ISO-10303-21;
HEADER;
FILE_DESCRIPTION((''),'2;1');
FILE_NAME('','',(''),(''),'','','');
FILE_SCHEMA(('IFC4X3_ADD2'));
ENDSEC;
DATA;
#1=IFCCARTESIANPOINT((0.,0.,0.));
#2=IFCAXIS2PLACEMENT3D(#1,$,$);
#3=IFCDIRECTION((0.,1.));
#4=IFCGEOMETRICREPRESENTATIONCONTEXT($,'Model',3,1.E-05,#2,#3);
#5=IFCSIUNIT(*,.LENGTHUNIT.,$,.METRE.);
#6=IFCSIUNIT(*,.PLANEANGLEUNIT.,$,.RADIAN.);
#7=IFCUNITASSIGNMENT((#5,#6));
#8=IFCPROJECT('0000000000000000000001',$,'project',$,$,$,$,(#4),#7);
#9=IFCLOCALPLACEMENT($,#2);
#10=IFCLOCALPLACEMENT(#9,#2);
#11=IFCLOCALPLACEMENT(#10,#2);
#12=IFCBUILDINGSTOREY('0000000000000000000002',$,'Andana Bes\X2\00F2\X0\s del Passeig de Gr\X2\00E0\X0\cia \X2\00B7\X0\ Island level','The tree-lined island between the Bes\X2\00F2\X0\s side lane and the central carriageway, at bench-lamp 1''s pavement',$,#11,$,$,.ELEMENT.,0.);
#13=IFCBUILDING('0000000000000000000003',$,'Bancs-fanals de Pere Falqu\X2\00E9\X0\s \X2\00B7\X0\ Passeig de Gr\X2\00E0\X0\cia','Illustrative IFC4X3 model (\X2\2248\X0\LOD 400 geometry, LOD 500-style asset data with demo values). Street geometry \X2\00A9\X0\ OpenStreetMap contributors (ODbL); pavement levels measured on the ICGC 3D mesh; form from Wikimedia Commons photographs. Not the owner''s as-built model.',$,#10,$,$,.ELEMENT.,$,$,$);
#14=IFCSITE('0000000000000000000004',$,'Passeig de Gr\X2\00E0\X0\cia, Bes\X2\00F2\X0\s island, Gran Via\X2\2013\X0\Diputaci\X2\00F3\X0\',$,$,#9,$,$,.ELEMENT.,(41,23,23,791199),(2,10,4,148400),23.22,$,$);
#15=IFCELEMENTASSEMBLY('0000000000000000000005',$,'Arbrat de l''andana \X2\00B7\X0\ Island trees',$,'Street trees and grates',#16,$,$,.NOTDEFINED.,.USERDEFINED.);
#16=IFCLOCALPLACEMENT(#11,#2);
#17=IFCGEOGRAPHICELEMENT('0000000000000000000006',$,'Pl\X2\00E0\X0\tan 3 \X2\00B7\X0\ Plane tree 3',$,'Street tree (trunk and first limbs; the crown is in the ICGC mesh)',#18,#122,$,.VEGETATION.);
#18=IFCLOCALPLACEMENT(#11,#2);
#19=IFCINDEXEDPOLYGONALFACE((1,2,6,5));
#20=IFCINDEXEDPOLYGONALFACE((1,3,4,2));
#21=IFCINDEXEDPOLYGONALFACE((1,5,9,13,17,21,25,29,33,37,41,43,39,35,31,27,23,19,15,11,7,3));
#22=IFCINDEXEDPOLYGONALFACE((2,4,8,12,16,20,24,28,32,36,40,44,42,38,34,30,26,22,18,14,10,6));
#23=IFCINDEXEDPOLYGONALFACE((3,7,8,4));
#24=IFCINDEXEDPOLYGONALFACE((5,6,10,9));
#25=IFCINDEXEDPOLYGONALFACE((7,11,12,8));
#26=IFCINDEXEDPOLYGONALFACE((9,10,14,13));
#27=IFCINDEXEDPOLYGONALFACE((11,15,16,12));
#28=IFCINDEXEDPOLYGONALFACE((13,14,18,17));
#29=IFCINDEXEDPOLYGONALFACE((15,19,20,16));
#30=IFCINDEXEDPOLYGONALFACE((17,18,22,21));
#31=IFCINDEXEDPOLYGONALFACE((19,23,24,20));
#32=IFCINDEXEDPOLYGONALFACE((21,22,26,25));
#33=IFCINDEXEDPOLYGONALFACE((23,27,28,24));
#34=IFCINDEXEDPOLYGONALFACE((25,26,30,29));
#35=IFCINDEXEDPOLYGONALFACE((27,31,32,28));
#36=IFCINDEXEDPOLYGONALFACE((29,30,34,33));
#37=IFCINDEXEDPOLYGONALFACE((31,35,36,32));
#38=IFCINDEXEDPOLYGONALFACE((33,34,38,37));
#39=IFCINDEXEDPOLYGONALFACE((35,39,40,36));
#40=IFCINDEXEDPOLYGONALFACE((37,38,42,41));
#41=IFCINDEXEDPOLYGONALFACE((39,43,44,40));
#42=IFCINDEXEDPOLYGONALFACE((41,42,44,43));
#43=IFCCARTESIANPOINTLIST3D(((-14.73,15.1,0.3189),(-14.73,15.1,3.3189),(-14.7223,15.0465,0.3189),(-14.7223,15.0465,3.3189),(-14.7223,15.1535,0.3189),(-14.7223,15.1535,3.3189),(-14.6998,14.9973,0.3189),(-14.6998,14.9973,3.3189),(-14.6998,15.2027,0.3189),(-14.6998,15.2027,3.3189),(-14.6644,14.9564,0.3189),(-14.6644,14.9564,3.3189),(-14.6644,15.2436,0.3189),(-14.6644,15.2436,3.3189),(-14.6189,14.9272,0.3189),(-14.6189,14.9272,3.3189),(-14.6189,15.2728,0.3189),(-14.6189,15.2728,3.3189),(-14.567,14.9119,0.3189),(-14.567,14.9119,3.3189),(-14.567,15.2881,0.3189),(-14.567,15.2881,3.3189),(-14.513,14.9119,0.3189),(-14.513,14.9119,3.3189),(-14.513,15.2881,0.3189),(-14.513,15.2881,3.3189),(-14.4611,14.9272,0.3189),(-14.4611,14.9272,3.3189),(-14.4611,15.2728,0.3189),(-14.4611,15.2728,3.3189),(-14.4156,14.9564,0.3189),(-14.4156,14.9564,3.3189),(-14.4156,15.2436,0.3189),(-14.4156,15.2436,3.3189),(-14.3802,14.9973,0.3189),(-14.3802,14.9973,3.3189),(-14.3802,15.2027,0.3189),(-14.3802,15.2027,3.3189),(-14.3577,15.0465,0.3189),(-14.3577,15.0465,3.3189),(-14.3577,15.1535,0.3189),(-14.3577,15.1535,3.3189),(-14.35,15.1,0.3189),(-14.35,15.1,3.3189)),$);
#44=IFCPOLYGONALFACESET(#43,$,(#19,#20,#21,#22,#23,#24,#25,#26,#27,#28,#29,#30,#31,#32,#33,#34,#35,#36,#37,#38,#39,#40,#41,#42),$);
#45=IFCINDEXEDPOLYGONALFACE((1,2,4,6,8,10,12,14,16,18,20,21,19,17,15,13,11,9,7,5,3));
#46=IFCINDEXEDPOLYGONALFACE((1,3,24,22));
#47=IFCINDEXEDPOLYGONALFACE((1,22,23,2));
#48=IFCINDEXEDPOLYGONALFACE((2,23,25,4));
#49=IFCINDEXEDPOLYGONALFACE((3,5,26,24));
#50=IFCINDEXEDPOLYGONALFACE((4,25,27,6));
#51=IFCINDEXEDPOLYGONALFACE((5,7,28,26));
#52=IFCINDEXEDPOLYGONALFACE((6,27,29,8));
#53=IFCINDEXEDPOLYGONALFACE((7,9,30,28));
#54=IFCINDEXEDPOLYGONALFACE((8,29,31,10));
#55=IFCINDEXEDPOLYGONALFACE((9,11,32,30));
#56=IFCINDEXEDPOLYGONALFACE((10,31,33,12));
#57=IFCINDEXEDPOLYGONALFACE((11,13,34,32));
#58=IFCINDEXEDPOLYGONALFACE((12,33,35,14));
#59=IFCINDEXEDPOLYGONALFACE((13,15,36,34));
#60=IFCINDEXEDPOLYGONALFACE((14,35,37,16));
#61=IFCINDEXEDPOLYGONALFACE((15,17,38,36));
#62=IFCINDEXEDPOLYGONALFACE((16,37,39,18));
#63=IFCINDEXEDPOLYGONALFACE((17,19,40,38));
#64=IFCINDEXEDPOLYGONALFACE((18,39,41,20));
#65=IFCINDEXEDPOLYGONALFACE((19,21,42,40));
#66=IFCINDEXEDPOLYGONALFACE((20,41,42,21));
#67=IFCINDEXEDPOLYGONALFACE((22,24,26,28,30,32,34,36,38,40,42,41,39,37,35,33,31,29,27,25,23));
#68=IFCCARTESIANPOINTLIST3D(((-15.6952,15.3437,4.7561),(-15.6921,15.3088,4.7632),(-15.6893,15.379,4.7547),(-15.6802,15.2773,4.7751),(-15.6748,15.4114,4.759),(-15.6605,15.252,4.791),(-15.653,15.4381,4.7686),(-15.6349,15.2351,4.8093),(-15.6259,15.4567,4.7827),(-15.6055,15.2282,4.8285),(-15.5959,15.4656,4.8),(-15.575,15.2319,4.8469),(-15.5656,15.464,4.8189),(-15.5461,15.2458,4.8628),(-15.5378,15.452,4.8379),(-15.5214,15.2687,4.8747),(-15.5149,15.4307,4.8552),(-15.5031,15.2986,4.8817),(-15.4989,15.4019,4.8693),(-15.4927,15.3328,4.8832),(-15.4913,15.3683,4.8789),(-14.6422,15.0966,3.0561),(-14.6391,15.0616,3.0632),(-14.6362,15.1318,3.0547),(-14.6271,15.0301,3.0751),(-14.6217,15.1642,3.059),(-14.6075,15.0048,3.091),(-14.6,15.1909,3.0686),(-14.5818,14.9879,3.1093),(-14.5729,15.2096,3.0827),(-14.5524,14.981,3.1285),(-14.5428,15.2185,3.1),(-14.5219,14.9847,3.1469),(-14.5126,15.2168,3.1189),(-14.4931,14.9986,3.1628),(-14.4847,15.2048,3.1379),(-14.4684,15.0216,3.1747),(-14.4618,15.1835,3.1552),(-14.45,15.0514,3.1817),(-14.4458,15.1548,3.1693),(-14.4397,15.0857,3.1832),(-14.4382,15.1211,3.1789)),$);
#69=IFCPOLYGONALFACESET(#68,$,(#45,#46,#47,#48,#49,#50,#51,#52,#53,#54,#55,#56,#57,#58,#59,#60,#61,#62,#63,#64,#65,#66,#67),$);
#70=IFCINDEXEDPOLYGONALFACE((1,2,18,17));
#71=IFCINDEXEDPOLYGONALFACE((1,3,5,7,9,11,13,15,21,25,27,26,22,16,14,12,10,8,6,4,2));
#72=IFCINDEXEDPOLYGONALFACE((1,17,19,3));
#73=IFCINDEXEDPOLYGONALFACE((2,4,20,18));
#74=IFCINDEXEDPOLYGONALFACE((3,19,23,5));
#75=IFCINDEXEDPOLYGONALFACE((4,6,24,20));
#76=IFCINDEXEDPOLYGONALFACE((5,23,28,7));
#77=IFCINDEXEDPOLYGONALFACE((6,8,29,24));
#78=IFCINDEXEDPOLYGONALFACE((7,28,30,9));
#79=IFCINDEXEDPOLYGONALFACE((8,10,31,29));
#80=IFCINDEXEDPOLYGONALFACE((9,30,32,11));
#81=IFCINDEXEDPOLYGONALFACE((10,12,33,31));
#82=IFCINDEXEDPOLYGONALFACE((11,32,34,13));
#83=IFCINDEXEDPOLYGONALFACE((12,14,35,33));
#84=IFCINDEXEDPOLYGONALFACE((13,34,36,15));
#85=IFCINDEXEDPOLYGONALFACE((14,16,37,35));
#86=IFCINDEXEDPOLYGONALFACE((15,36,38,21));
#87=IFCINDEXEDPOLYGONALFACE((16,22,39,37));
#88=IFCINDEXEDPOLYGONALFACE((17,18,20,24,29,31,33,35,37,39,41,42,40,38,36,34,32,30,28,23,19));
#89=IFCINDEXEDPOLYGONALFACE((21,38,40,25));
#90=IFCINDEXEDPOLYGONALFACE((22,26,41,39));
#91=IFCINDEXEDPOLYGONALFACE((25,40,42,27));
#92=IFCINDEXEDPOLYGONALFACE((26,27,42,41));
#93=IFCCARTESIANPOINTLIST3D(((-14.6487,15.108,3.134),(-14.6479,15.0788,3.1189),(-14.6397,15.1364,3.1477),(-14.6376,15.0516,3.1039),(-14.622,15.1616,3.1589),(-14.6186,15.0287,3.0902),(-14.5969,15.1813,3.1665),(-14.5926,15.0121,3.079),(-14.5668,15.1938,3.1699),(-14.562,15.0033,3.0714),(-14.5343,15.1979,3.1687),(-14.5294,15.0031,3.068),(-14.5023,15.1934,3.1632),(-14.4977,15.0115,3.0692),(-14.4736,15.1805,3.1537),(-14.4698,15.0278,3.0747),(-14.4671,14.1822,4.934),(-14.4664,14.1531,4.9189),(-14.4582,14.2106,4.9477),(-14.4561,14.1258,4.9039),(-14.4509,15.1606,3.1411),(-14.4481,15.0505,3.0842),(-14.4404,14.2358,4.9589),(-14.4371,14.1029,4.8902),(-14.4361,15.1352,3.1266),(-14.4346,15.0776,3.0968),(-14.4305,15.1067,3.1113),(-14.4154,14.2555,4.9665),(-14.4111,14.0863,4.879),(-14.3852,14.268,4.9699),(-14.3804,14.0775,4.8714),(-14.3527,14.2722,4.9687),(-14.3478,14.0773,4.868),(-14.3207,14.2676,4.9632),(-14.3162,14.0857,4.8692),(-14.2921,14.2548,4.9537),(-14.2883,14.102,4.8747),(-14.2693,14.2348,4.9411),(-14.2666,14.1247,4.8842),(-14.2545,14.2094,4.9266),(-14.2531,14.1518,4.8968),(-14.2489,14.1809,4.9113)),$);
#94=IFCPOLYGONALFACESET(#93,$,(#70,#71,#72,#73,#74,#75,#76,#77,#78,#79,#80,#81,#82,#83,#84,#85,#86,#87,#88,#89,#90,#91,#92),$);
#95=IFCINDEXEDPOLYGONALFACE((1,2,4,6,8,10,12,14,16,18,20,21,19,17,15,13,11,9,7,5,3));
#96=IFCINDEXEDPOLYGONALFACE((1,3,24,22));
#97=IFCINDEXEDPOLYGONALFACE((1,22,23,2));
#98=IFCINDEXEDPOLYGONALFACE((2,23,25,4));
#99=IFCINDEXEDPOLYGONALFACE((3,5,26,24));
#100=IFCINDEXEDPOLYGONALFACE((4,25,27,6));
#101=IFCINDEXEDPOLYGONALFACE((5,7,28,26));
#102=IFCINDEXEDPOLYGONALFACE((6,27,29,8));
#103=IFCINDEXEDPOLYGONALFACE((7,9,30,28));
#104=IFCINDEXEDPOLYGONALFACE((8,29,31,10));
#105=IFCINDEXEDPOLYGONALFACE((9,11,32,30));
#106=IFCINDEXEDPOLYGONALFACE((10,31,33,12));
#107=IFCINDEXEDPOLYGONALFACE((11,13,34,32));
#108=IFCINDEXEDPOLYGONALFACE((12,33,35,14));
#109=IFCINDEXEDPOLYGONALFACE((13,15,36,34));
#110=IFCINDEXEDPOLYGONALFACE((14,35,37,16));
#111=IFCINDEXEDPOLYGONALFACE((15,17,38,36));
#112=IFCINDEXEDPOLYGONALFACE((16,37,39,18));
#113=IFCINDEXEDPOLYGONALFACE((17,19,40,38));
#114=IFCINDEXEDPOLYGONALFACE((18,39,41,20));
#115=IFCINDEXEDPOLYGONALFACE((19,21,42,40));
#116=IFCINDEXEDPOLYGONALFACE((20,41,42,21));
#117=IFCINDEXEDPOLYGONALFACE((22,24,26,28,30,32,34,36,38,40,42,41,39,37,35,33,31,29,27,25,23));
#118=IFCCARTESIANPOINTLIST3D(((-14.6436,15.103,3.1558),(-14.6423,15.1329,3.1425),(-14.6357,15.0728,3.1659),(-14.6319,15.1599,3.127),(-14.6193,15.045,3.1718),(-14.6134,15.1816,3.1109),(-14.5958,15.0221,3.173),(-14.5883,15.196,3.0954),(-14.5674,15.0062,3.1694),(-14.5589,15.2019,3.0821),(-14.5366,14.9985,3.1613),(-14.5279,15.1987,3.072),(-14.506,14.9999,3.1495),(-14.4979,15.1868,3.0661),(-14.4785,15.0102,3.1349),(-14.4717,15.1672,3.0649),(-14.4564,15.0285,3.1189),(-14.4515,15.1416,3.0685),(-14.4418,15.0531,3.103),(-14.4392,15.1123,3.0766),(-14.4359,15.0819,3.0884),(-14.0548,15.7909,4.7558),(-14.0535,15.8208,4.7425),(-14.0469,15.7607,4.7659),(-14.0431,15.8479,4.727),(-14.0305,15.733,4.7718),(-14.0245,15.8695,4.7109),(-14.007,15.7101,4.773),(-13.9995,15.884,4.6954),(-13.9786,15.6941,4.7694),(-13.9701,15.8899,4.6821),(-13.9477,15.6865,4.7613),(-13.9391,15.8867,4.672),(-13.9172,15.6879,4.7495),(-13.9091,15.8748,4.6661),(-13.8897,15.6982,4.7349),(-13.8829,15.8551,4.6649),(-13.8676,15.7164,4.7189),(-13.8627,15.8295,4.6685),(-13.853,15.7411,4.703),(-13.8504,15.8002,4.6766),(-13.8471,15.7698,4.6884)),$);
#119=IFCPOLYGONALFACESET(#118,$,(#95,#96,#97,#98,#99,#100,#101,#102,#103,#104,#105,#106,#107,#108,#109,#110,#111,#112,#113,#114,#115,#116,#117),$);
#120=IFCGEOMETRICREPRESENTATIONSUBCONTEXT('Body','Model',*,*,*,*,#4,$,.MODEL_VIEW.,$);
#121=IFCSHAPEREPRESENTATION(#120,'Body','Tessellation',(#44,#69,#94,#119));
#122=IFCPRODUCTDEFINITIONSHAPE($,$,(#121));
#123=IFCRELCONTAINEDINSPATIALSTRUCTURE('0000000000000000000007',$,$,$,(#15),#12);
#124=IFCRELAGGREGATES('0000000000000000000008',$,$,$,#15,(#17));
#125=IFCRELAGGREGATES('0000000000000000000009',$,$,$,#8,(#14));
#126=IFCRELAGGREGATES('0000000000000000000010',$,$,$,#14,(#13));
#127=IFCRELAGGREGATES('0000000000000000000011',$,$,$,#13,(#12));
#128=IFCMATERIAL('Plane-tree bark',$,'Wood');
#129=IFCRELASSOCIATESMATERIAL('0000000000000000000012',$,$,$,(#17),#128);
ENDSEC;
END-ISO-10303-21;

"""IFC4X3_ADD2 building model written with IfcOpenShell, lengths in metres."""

from ifc_helpers import new_model, si_unit, direction, frame, origin, origin_2d_with_axis, place, context, subcontext, project, spatial, circle, extrude, material, element, aggregate, save


model = new_model("IFC4X3_ADD2")

# Units and contexts
model_context = context("Model", 3, precision=1e-05, world=origin(), true_north=direction((0.0, 1.0)))
body_context = subcontext(model_context, "Body", "Model", "MODEL_VIEW")
ifc_project = project(units=[si_unit("LENGTHUNIT", "METRE"), si_unit("PLANEANGLEUNIT", "RADIAN")], contexts=[model_context])

# Site, building, storey
site_placement = place(None, origin())
site = spatial("IfcSite", under=ifc_project, at=site_placement, Name="Passeig de Gràcia, Besòs island, Gran Via–Diputació", CompositionType="ELEMENT", RefLatitude=(41, 23, 23, 791199), RefLongitude=(2, 10, 4, 148400), RefElevation=23.22)
building_placement = place(site_placement, origin())
building = spatial("IfcBuilding", under=site, at=building_placement, Name="Bancs-fanals de Pere Falqués · Passeig de Gràcia", Description="Illustrative IFC4X3 model (≈LOD 400 geometry, LOD 500-style asset data with demo values). Street geometry © OpenStreetMap contributors (ODbL); pavement levels measured on the ICGC 3D mesh; form from Wikimedia Commons photographs. Not the owner's as-built model.", CompositionType="ELEMENT")
storey_placement = place(building_placement, origin())
storey = spatial("IfcBuildingStorey", under=building, at=storey_placement, Name="Andana Besòs del Passeig de Gràcia · Island level", Description="The tree-lined island between the Besòs side lane and the central carriageway, at bench-lamp 1's pavement", CompositionType="ELEMENT", Elevation=0.0)

# Element assembly
assembly_1_placement = place(building_placement, origin())
assembly_1 = element("IfcElementAssembly", 1, at=assembly_1_placement, inside=storey, Name="Arbrat de l'andana · Island trees", ObjectType="Street trees and grates", AssemblyPlace="NOTDEFINED", PredefinedType="USERDEFINED")

# Geographic element
ifc_material_1 = material(Name="Plane-tree bark", Category="Wood")
geographic_element_1_placement = place(building_placement, origin())
geographic_element_1 = element("IfcGeographicElement", 2, at=geographic_element_1_placement, material=ifc_material_1, Name="Plàtan 3 · Plane tree 3", ObjectType="Street tree (trunk and first limbs; the crown is in the ICGC mesh)", PredefinedType="VEGETATION", context=body_context, shape_type="SweptSolid", body=[
    extrude(circle(Radius=0.19, at=origin_2d_with_axis()), frame((-14.54, 15.1, 0.3189)), (0.0, 0.0, 1.0), 3.0),
    extrude(circle(Radius=0.12, at=origin_2d_with_axis()), frame((-14.54, 15.1, 3.1189), z_axis=(-0.522617, 0.122674, 0.843696), x_axis=(0.22852, 0.973539, 0.0)), (0.0, 0.0, 1.0), 2.0149),
    extrude(circle(Radius=0.11, at=origin_2d_with_axis()), frame((-14.54, 15.1, 3.1189), z_axis=(0.089329, -0.45554, 0.885722), x_axis=(-0.981311, -0.19243, 0.0)), (0.0, 0.0, 1.0), 2.0322),
    extrude(circle(Radius=0.11, at=origin_2d_with_axis()), frame((-14.54, 15.1, 3.1189), z_axis=(0.320275, 0.374202, 0.870285), x_axis=(0.759728, -0.650241, 0.0)), (0.0, 0.0, 1.0), 1.8385),
])
aggregate(assembly_1, [geographic_element_1])

save(model, "model.ifc")
